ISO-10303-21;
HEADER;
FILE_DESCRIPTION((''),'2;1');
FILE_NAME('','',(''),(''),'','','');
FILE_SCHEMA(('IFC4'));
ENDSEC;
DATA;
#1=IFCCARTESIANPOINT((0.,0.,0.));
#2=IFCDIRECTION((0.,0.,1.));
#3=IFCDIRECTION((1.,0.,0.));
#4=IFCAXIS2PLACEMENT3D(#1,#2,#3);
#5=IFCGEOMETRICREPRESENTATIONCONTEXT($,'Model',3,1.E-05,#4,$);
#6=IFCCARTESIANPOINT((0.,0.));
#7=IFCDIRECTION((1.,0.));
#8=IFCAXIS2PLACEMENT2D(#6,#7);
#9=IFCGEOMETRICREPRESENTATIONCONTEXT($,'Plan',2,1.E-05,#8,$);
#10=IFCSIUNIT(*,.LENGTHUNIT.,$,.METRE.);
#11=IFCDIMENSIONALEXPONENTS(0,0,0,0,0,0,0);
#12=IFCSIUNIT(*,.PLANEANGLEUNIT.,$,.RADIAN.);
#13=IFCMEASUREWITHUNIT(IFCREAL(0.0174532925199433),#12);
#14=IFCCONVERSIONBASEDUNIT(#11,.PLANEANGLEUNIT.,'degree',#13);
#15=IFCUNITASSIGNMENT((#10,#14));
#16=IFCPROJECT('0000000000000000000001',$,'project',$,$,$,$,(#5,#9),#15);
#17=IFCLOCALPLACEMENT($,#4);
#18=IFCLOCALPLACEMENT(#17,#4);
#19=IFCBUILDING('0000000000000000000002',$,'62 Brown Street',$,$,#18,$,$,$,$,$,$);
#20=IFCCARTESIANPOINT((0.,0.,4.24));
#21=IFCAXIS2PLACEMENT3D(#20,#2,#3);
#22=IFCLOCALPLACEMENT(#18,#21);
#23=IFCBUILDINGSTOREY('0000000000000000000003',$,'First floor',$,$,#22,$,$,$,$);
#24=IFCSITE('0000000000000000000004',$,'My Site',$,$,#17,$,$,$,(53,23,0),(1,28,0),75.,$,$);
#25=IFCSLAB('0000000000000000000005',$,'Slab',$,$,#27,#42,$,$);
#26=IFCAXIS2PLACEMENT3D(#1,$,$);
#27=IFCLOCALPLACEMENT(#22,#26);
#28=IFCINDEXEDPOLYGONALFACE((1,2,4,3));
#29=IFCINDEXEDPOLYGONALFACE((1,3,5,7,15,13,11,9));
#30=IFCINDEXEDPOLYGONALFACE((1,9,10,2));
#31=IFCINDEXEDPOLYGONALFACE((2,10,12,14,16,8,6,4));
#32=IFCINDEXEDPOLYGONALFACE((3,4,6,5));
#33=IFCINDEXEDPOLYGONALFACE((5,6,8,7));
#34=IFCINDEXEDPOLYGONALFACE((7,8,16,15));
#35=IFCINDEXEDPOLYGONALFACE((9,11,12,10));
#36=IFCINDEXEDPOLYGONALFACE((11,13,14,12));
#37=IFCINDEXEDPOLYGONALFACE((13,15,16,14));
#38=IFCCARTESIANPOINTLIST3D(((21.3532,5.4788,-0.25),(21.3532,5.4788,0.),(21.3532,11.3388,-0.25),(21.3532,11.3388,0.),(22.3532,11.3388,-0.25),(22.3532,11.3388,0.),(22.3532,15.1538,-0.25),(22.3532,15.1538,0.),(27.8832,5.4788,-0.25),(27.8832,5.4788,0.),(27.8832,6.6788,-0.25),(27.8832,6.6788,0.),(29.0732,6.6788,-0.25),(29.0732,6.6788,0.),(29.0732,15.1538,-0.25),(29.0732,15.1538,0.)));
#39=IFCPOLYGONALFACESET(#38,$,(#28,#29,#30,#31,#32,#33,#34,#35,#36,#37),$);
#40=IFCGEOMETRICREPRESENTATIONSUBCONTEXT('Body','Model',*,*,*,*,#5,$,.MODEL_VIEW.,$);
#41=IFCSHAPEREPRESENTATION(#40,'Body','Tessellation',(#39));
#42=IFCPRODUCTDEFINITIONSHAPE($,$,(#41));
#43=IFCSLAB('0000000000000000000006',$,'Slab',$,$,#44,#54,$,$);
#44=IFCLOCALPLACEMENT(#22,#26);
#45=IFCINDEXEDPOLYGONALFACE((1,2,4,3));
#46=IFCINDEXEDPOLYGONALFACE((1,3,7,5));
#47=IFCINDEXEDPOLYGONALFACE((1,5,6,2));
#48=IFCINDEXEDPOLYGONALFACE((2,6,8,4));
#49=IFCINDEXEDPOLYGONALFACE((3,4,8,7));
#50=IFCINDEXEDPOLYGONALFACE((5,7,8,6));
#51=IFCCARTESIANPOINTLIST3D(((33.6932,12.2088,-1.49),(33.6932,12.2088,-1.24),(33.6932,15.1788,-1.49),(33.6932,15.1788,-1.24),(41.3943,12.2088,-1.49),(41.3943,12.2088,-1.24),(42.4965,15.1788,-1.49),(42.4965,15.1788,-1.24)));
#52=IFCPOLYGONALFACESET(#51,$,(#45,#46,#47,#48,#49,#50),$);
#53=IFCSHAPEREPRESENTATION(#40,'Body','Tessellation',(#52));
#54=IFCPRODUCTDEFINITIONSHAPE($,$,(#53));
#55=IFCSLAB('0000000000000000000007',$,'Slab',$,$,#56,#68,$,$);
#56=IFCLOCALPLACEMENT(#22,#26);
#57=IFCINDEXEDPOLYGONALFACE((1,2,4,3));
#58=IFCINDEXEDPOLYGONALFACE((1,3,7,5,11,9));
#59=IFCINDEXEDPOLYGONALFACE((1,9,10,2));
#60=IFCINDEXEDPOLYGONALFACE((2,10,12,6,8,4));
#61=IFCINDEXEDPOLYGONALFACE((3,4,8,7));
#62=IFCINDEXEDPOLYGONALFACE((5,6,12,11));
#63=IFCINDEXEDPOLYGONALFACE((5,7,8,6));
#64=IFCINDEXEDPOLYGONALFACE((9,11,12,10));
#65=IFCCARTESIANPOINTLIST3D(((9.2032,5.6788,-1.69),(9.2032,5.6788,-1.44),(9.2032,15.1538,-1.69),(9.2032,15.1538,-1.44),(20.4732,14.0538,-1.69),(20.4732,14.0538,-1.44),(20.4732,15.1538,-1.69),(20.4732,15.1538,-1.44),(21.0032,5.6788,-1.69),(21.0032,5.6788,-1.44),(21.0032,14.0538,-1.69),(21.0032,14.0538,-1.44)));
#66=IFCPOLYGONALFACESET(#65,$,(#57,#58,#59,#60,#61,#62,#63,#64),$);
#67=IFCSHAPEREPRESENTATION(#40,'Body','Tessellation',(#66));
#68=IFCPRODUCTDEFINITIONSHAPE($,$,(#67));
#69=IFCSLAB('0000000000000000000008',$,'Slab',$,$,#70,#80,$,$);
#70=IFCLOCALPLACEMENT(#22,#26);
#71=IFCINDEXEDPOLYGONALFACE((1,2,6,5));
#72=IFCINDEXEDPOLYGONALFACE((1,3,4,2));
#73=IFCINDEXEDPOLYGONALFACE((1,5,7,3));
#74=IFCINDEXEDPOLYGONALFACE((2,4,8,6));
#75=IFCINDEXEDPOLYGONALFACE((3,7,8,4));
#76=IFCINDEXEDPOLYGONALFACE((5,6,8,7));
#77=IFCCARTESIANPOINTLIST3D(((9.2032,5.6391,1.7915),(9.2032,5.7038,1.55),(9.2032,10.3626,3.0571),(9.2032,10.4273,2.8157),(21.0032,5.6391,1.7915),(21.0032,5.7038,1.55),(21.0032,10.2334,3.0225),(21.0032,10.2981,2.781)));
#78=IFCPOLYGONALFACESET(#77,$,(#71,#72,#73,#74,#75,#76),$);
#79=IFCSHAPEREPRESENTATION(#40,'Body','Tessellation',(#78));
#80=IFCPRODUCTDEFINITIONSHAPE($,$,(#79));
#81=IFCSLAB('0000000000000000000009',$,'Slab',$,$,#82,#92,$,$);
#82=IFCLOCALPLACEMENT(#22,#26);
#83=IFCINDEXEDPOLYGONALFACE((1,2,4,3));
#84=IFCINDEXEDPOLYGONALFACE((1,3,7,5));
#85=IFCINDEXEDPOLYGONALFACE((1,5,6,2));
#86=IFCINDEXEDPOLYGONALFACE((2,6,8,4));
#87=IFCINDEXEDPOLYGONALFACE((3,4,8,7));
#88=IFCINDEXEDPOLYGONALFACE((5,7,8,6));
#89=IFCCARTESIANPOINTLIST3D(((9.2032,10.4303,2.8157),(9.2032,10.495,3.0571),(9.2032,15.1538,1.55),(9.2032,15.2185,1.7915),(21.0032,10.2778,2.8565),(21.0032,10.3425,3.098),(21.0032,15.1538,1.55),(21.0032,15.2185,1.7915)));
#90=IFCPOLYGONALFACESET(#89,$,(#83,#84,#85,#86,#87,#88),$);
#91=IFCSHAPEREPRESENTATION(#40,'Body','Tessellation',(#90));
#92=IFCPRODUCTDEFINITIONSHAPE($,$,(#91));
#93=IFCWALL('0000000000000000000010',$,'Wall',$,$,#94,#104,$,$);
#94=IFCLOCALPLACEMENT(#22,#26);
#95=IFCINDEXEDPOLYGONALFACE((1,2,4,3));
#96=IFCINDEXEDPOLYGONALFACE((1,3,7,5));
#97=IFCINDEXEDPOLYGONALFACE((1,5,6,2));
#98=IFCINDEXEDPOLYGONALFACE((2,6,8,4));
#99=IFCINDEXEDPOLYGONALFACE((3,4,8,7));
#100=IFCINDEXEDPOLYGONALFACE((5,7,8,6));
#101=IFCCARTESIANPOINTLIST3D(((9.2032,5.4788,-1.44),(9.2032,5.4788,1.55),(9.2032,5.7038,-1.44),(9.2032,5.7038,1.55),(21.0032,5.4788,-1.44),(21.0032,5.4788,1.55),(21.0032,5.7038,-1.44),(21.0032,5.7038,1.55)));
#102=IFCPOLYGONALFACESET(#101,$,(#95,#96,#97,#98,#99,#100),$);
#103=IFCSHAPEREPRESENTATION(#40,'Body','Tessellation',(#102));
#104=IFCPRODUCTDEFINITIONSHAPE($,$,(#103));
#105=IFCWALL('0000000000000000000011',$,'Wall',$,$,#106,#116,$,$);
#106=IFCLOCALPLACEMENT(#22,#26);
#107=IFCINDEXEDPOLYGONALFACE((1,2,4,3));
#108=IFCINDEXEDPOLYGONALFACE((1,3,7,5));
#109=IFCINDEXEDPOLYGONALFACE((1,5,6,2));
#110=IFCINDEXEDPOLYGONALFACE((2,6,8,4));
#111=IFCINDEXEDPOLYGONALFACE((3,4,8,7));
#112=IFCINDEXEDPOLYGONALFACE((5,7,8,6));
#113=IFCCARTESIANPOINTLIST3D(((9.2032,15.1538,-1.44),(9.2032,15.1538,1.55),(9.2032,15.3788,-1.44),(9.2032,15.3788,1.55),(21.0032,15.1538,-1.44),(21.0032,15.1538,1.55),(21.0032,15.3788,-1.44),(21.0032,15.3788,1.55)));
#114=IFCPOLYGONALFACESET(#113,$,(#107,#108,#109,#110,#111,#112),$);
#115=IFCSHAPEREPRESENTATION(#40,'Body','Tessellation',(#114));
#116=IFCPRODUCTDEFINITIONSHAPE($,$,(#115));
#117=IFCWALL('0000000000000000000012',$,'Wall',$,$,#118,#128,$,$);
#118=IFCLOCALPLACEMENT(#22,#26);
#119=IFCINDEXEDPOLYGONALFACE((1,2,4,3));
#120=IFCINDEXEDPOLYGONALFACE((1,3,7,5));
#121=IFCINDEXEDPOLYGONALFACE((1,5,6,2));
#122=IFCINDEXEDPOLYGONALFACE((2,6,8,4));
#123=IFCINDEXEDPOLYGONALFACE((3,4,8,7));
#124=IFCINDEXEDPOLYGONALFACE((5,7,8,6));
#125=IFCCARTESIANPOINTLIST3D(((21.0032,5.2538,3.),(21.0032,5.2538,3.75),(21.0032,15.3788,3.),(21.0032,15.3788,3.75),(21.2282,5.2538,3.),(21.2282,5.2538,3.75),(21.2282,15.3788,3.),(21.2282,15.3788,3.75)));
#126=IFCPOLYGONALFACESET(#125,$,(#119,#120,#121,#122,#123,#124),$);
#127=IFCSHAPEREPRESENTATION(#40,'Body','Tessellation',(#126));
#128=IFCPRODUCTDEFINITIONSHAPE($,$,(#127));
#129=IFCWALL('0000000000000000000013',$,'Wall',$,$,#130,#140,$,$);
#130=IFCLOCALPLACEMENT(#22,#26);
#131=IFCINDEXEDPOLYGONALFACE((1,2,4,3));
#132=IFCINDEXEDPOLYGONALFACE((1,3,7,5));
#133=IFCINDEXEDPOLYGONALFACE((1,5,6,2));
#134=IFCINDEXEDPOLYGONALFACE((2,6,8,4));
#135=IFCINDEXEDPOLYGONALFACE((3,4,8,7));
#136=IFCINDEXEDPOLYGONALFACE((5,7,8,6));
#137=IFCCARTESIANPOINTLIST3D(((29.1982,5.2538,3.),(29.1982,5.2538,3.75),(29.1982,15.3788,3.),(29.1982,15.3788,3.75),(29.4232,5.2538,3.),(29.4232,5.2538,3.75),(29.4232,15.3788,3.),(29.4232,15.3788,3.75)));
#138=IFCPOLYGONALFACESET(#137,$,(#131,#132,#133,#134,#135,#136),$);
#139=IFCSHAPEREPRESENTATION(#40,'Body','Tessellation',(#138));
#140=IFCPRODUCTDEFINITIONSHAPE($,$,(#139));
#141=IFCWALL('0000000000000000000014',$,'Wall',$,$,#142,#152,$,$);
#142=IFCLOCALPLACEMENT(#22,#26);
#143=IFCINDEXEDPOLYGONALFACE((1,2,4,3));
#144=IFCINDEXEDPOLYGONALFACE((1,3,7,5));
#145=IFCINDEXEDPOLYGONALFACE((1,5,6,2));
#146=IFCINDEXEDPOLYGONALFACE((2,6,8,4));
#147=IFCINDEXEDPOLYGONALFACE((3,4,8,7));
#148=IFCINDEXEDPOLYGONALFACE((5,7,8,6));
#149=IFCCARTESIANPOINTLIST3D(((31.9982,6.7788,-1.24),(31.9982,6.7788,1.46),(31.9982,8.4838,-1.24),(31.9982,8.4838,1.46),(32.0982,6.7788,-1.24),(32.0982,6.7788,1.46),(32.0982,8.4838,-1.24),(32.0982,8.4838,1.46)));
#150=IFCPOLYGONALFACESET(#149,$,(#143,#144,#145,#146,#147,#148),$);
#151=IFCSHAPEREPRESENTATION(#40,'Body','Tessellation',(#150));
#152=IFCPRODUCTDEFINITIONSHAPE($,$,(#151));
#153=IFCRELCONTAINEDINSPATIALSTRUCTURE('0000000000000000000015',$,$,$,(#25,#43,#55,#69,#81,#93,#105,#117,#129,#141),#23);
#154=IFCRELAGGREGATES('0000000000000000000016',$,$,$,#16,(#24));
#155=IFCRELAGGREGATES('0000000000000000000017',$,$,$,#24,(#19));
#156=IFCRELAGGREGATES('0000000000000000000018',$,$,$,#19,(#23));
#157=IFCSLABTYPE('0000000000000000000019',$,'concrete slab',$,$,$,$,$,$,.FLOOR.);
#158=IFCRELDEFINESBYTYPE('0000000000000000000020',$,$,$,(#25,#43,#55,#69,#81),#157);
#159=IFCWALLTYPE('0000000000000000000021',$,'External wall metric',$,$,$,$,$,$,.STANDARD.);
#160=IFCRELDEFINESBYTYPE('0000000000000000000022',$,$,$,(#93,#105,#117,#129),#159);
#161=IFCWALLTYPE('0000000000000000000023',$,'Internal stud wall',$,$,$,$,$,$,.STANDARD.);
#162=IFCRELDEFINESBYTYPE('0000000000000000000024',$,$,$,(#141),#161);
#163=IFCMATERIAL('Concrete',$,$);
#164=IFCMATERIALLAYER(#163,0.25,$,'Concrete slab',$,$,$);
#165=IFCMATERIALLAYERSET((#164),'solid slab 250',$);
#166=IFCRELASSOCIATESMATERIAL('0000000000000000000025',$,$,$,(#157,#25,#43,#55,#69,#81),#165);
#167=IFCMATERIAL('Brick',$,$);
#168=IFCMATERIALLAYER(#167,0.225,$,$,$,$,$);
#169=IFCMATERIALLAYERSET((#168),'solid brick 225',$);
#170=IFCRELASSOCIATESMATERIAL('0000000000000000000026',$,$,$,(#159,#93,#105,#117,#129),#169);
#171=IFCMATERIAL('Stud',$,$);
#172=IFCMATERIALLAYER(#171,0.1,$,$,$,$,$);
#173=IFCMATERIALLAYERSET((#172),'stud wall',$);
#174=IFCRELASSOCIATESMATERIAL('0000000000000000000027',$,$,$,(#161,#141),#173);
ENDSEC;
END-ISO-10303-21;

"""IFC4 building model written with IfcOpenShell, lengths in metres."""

from ifc_helpers import new_model, entity, si_unit, converted_unit, frame, origin_with_axes, origin_2d_with_axis, place, context, subcontext, project, spatial, line, indexed_curve, outline, extrude, material, layer, layer_set, layer_usage, type_object, element, save


model = new_model("IFC4")

# Units and contexts
model_context = context("Model", 3, precision=1e-05, world=origin_with_axes())
plan_context = context("Plan", 2, precision=1e-05, world=origin_2d_with_axis())
body_context_1 = subcontext(model_context, "Body", "Model", "MODEL_VIEW")
ifc_project = project(units=[si_unit("LENGTHUNIT", "METRE"), converted_unit("PLANEANGLEUNIT", "degree", entity("IfcReal", 0.0174532925199433), si_unit("PLANEANGLEUNIT", "RADIAN"), dimensions=[0, 0, 0, 0, 0, 0, 0])], contexts=[model_context, plan_context])

# Site, building, storey
site_placement = place(None, origin_with_axes())
site = spatial("IfcSite", under=ifc_project, at=site_placement, Name="My Site", RefLatitude=(53, 23, 0), RefLongitude=(1, 28, 0), RefElevation=75.0)
building_placement = place(site_placement, origin_with_axes())
building = spatial("IfcBuilding", under=site, at=building_placement, Name="62 Brown Street")
storey_placement = place(building_placement, frame((0.0, 0.0, 4.24), z_axis=(0.0, 0.0, 1.0), x_axis=(1.0, 0.0, 0.0)))
storey = spatial("IfcBuildingStorey", under=building, at=storey_placement, Name="First floor")

# Slabs
ifc_material_1 = material(Name="Concrete")
ifc_layer_1 = layer(ifc_material_1, 0.25, Name="Concrete slab")
ifc_layer_set_1 = layer_set([ifc_layer_1], Name="solid slab 250")
ifc_layer_usage_1 = layer_usage(ifc_layer_set_1, "AXIS3", "POSITIVE", 0.0)
slab_type = type_object("IfcSlabType", Name="concrete slab", PredefinedType="FLOOR", material=ifc_layer_set_1)
slab_1_placement = place(storey_placement, frame((21.3532, 5.4788, -0.25), z_axis=(0.0, 0.0, 1.0), x_axis=(1.0, 0.0, 0.0)))
element("IfcSlab", 1, at=slab_1_placement, inside=storey, type_object=slab_type, material=ifc_layer_usage_1, Name="Slab", context=body_context_1, shape_type="SweptSolid", body=[
    extrude(outline(indexed_curve([(6.53, 1.2), (7.72, 1.2), (7.72, 9.675), (1.0, 9.675), (1.0, 5.86), (0.0, 5.86), (0.0, 0.0), (6.53, 0.0), (6.53, 1.2)])), None, (0.0, 0.0, 1.0), 0.25),
])
ifc_layer_usage_2 = layer_usage(ifc_layer_set_1, "AXIS3", "POSITIVE", 0.0)
slab_2_placement = place(storey_placement, frame((33.6932, 12.2088, -1.49), z_axis=(0.0, 0.0, 1.0), x_axis=(1.0, 0.0, 0.0)))
element("IfcSlab", 2, at=slab_2_placement, inside=storey, type_object=slab_type, material=ifc_layer_usage_2, Name="Slab", context=body_context_1, shape_type="SweptSolid", body=[
    extrude(outline(indexed_curve([(8.8033, 2.97), (7.7011, 0.0), (0.0, 0.0), (0.0, 2.97)], segments=[line(4, 1), line(1, 2), line(2, 3), line(3, 4)], self_intersect=False)), None, (0.0, 0.0, 1.0), 0.25),
])
ifc_layer_usage_3 = layer_usage(ifc_layer_set_1, "AXIS3", "POSITIVE", 0.0)
slab_3_placement = place(storey_placement, frame((9.2032, 5.6788, -1.69), z_axis=(0.0, 0.0, 1.0), x_axis=(1.0, 0.0, 0.0)))
element("IfcSlab", 3, at=slab_3_placement, inside=storey, type_object=slab_type, material=ifc_layer_usage_3, Name="Slab", context=body_context_1, shape_type="SweptSolid", body=[
    extrude(outline(indexed_curve([(11.27, 9.475), (11.8, 0.0), (0.0, 0.0), (0.0, 9.475), (11.8, 8.375), (11.27, 8.375)], segments=[line(6, 1), line(1, 4), line(4, 3), line(3, 2), line(2, 5), line(5, 6)], self_intersect=False)), None, (0.0, 0.0, 1.0), 0.25),
])
ifc_layer_usage_4 = layer_usage(ifc_layer_set_1, "AXIS3", "POSITIVE", 0.0)
slab_4_placement = place(storey_placement, frame((9.2032, 5.7038, 1.55), z_axis=(0.0, -0.258819, 0.965926), x_axis=(1.0, 0.0, 0.0)))
element("IfcSlab", 4, at=slab_4_placement, inside=storey, type_object=slab_type, material=ifc_layer_usage_4, Name="Slab", context=body_context_1, shape_type="SweptSolid", body=[
    extrude(outline(indexed_curve([(0.0, 4.8901), (0.0, 0.0), (11.8, 0.0), (11.8, 4.7563)], segments=[line(3, 2), line(2, 1), line(1, 4), line(4, 3)], self_intersect=False)), None, (0.0, 0.0, 1.0), 0.25),
])
ifc_layer_usage_5 = layer_usage(ifc_layer_set_1, "AXIS3", "POSITIVE", 0.0)
slab_5_placement = place(storey_placement, frame((21.0032, 15.1538, 1.55), z_axis=(0.0, 0.258819, 0.965926), x_axis=(-1.0, 0.0, 0.0)))
element("IfcSlab", 5, at=slab_5_placement, inside=storey, type_object=slab_type, material=ifc_layer_usage_5, Name="Slab", context=body_context_1, shape_type="SweptSolid", body=[
    extrude(outline(indexed_curve([(0.0, 0.0), (11.8, 0.0), (11.8, 4.8901), (0.0, 5.048)], segments=[line(4, 1), line(1, 2), line(2, 3), line(3, 4)], self_intersect=False)), None, (0.0, 0.0, 1.0), 0.25),
])

# Walls
ifc_material_2 = material(Name="Brick")
ifc_layer_2 = layer(ifc_material_2, 0.225)
ifc_layer_set_2 = layer_set([ifc_layer_2], Name="solid brick 225")
ifc_layer_usage_6 = layer_usage(ifc_layer_set_2, "AXIS2", "POSITIVE", 0.0)
wall_type_1 = type_object("IfcWallType", Name="External wall metric", PredefinedType="STANDARD", material=ifc_layer_set_2)
wall_1_placement = place(storey_placement, frame((9.2032, 5.4788, -1.44), z_axis=(0.0, 0.0, 1.0), x_axis=(1.0, 0.0, 0.0)))
element("IfcWall", 6, at=wall_1_placement, inside=storey, type_object=wall_type_1, material=ifc_layer_usage_6, Name="Wall", context=body_context_1, shape_type="SweptSolid", body=[
    extrude(outline(indexed_curve([(0.0, 0.0), (0.0, 0.225), (11.8, 0.225), (11.8, 0.0), (0.0, 0.0)], self_intersect=False)), origin_with_axes(), (0.0, 0.0, 1.0), 2.99),
])
ifc_layer_usage_7 = layer_usage(ifc_layer_set_2, "AXIS2", "POSITIVE", 0.0)
wall_2_placement = place(storey_placement, frame((21.0032, 15.3788, -1.44), z_axis=(0.0, 0.0, 1.0), x_axis=(-1.0, 0.0, 0.0)))
element("IfcWall", 7, at=wall_2_placement, inside=storey, type_object=wall_type_1, material=ifc_layer_usage_7, Name="Wall", context=body_context_1, shape_type="SweptSolid", body=[
    extrude(outline(indexed_curve([(0.0, 0.0), (0.0, 0.225), (11.8, 0.225), (11.8, 0.0), (0.0, 0.0)], self_intersect=False)), origin_with_axes(), (0.0, 0.0, 1.0), 2.99),
])

# Walls
ifc_layer_usage_8 = layer_usage(ifc_layer_set_2, "AXIS2", "POSITIVE", 0.0)
wall_3_placement = place(storey_placement, frame((21.0032, 15.3788, 3.0), z_axis=(0.0, 0.0, 1.0), x_axis=(0.0, -1.0, 0.0)))
element("IfcWall", 8, at=wall_3_placement, inside=storey, type_object=wall_type_1, material=ifc_layer_usage_8, Name="Wall", context=body_context_1, shape_type="SweptSolid", body=[
    extrude(outline(indexed_curve([(0.0, 0.0), (0.0, 0.225), (10.125, 0.225), (10.125, 0.0), (0.0, 0.0)], self_intersect=False)), origin_with_axes(), (0.0, 0.0, 1.0), 0.75),
])
ifc_layer_usage_9 = layer_usage(ifc_layer_set_2, "AXIS2", "POSITIVE", 0.0)
wall_4_placement = place(storey_placement, frame((29.4232, 5.2538, 3.0), z_axis=(0.0, 0.0, 1.0), x_axis=(0.0, 1.0, 0.0)))
element("IfcWall", 9, at=wall_4_placement, inside=storey, type_object=wall_type_1, material=ifc_layer_usage_9, Name="Wall", context=body_context_1, shape_type="SweptSolid", body=[
    extrude(outline(indexed_curve([(0.0, 0.0), (0.0, 0.225), (10.125, 0.225), (10.125, 0.0), (0.0, 0.0)], self_intersect=False)), origin_with_axes(), (0.0, 0.0, 1.0), 0.75),
])
ifc_material_3 = material(Name="Stud")
ifc_layer_3 = layer(ifc_material_3, 0.1)
ifc_layer_set_3 = layer_set([ifc_layer_3], Name="stud wall")
ifc_layer_usage_10 = layer_usage(ifc_layer_set_3, "AXIS2", "POSITIVE", 0.0)
wall_type_2 = type_object("IfcWallType", Name="Internal stud wall", PredefinedType="STANDARD", material=ifc_layer_set_3)
wall_5_placement = place(storey_placement, frame((32.0982, 6.7788, -1.24), z_axis=(0.0, 0.0, 1.0), x_axis=(0.000001, 1.0, 0.0)))
element("IfcWall", 10, at=wall_5_placement, inside=storey, type_object=wall_type_2, material=ifc_layer_usage_10, Name="Wall", context=body_context_1, shape_type="SweptSolid", body=[
    extrude(outline(indexed_curve([(0.0, 0.0), (0.0, 0.1), (1.705, 0.1), (1.705, 0.0), (0.0, 0.0)], self_intersect=False)), origin_with_axes(), (0.0, 0.0, 1.0), 2.7),
])

save(model, "model.ifc")
